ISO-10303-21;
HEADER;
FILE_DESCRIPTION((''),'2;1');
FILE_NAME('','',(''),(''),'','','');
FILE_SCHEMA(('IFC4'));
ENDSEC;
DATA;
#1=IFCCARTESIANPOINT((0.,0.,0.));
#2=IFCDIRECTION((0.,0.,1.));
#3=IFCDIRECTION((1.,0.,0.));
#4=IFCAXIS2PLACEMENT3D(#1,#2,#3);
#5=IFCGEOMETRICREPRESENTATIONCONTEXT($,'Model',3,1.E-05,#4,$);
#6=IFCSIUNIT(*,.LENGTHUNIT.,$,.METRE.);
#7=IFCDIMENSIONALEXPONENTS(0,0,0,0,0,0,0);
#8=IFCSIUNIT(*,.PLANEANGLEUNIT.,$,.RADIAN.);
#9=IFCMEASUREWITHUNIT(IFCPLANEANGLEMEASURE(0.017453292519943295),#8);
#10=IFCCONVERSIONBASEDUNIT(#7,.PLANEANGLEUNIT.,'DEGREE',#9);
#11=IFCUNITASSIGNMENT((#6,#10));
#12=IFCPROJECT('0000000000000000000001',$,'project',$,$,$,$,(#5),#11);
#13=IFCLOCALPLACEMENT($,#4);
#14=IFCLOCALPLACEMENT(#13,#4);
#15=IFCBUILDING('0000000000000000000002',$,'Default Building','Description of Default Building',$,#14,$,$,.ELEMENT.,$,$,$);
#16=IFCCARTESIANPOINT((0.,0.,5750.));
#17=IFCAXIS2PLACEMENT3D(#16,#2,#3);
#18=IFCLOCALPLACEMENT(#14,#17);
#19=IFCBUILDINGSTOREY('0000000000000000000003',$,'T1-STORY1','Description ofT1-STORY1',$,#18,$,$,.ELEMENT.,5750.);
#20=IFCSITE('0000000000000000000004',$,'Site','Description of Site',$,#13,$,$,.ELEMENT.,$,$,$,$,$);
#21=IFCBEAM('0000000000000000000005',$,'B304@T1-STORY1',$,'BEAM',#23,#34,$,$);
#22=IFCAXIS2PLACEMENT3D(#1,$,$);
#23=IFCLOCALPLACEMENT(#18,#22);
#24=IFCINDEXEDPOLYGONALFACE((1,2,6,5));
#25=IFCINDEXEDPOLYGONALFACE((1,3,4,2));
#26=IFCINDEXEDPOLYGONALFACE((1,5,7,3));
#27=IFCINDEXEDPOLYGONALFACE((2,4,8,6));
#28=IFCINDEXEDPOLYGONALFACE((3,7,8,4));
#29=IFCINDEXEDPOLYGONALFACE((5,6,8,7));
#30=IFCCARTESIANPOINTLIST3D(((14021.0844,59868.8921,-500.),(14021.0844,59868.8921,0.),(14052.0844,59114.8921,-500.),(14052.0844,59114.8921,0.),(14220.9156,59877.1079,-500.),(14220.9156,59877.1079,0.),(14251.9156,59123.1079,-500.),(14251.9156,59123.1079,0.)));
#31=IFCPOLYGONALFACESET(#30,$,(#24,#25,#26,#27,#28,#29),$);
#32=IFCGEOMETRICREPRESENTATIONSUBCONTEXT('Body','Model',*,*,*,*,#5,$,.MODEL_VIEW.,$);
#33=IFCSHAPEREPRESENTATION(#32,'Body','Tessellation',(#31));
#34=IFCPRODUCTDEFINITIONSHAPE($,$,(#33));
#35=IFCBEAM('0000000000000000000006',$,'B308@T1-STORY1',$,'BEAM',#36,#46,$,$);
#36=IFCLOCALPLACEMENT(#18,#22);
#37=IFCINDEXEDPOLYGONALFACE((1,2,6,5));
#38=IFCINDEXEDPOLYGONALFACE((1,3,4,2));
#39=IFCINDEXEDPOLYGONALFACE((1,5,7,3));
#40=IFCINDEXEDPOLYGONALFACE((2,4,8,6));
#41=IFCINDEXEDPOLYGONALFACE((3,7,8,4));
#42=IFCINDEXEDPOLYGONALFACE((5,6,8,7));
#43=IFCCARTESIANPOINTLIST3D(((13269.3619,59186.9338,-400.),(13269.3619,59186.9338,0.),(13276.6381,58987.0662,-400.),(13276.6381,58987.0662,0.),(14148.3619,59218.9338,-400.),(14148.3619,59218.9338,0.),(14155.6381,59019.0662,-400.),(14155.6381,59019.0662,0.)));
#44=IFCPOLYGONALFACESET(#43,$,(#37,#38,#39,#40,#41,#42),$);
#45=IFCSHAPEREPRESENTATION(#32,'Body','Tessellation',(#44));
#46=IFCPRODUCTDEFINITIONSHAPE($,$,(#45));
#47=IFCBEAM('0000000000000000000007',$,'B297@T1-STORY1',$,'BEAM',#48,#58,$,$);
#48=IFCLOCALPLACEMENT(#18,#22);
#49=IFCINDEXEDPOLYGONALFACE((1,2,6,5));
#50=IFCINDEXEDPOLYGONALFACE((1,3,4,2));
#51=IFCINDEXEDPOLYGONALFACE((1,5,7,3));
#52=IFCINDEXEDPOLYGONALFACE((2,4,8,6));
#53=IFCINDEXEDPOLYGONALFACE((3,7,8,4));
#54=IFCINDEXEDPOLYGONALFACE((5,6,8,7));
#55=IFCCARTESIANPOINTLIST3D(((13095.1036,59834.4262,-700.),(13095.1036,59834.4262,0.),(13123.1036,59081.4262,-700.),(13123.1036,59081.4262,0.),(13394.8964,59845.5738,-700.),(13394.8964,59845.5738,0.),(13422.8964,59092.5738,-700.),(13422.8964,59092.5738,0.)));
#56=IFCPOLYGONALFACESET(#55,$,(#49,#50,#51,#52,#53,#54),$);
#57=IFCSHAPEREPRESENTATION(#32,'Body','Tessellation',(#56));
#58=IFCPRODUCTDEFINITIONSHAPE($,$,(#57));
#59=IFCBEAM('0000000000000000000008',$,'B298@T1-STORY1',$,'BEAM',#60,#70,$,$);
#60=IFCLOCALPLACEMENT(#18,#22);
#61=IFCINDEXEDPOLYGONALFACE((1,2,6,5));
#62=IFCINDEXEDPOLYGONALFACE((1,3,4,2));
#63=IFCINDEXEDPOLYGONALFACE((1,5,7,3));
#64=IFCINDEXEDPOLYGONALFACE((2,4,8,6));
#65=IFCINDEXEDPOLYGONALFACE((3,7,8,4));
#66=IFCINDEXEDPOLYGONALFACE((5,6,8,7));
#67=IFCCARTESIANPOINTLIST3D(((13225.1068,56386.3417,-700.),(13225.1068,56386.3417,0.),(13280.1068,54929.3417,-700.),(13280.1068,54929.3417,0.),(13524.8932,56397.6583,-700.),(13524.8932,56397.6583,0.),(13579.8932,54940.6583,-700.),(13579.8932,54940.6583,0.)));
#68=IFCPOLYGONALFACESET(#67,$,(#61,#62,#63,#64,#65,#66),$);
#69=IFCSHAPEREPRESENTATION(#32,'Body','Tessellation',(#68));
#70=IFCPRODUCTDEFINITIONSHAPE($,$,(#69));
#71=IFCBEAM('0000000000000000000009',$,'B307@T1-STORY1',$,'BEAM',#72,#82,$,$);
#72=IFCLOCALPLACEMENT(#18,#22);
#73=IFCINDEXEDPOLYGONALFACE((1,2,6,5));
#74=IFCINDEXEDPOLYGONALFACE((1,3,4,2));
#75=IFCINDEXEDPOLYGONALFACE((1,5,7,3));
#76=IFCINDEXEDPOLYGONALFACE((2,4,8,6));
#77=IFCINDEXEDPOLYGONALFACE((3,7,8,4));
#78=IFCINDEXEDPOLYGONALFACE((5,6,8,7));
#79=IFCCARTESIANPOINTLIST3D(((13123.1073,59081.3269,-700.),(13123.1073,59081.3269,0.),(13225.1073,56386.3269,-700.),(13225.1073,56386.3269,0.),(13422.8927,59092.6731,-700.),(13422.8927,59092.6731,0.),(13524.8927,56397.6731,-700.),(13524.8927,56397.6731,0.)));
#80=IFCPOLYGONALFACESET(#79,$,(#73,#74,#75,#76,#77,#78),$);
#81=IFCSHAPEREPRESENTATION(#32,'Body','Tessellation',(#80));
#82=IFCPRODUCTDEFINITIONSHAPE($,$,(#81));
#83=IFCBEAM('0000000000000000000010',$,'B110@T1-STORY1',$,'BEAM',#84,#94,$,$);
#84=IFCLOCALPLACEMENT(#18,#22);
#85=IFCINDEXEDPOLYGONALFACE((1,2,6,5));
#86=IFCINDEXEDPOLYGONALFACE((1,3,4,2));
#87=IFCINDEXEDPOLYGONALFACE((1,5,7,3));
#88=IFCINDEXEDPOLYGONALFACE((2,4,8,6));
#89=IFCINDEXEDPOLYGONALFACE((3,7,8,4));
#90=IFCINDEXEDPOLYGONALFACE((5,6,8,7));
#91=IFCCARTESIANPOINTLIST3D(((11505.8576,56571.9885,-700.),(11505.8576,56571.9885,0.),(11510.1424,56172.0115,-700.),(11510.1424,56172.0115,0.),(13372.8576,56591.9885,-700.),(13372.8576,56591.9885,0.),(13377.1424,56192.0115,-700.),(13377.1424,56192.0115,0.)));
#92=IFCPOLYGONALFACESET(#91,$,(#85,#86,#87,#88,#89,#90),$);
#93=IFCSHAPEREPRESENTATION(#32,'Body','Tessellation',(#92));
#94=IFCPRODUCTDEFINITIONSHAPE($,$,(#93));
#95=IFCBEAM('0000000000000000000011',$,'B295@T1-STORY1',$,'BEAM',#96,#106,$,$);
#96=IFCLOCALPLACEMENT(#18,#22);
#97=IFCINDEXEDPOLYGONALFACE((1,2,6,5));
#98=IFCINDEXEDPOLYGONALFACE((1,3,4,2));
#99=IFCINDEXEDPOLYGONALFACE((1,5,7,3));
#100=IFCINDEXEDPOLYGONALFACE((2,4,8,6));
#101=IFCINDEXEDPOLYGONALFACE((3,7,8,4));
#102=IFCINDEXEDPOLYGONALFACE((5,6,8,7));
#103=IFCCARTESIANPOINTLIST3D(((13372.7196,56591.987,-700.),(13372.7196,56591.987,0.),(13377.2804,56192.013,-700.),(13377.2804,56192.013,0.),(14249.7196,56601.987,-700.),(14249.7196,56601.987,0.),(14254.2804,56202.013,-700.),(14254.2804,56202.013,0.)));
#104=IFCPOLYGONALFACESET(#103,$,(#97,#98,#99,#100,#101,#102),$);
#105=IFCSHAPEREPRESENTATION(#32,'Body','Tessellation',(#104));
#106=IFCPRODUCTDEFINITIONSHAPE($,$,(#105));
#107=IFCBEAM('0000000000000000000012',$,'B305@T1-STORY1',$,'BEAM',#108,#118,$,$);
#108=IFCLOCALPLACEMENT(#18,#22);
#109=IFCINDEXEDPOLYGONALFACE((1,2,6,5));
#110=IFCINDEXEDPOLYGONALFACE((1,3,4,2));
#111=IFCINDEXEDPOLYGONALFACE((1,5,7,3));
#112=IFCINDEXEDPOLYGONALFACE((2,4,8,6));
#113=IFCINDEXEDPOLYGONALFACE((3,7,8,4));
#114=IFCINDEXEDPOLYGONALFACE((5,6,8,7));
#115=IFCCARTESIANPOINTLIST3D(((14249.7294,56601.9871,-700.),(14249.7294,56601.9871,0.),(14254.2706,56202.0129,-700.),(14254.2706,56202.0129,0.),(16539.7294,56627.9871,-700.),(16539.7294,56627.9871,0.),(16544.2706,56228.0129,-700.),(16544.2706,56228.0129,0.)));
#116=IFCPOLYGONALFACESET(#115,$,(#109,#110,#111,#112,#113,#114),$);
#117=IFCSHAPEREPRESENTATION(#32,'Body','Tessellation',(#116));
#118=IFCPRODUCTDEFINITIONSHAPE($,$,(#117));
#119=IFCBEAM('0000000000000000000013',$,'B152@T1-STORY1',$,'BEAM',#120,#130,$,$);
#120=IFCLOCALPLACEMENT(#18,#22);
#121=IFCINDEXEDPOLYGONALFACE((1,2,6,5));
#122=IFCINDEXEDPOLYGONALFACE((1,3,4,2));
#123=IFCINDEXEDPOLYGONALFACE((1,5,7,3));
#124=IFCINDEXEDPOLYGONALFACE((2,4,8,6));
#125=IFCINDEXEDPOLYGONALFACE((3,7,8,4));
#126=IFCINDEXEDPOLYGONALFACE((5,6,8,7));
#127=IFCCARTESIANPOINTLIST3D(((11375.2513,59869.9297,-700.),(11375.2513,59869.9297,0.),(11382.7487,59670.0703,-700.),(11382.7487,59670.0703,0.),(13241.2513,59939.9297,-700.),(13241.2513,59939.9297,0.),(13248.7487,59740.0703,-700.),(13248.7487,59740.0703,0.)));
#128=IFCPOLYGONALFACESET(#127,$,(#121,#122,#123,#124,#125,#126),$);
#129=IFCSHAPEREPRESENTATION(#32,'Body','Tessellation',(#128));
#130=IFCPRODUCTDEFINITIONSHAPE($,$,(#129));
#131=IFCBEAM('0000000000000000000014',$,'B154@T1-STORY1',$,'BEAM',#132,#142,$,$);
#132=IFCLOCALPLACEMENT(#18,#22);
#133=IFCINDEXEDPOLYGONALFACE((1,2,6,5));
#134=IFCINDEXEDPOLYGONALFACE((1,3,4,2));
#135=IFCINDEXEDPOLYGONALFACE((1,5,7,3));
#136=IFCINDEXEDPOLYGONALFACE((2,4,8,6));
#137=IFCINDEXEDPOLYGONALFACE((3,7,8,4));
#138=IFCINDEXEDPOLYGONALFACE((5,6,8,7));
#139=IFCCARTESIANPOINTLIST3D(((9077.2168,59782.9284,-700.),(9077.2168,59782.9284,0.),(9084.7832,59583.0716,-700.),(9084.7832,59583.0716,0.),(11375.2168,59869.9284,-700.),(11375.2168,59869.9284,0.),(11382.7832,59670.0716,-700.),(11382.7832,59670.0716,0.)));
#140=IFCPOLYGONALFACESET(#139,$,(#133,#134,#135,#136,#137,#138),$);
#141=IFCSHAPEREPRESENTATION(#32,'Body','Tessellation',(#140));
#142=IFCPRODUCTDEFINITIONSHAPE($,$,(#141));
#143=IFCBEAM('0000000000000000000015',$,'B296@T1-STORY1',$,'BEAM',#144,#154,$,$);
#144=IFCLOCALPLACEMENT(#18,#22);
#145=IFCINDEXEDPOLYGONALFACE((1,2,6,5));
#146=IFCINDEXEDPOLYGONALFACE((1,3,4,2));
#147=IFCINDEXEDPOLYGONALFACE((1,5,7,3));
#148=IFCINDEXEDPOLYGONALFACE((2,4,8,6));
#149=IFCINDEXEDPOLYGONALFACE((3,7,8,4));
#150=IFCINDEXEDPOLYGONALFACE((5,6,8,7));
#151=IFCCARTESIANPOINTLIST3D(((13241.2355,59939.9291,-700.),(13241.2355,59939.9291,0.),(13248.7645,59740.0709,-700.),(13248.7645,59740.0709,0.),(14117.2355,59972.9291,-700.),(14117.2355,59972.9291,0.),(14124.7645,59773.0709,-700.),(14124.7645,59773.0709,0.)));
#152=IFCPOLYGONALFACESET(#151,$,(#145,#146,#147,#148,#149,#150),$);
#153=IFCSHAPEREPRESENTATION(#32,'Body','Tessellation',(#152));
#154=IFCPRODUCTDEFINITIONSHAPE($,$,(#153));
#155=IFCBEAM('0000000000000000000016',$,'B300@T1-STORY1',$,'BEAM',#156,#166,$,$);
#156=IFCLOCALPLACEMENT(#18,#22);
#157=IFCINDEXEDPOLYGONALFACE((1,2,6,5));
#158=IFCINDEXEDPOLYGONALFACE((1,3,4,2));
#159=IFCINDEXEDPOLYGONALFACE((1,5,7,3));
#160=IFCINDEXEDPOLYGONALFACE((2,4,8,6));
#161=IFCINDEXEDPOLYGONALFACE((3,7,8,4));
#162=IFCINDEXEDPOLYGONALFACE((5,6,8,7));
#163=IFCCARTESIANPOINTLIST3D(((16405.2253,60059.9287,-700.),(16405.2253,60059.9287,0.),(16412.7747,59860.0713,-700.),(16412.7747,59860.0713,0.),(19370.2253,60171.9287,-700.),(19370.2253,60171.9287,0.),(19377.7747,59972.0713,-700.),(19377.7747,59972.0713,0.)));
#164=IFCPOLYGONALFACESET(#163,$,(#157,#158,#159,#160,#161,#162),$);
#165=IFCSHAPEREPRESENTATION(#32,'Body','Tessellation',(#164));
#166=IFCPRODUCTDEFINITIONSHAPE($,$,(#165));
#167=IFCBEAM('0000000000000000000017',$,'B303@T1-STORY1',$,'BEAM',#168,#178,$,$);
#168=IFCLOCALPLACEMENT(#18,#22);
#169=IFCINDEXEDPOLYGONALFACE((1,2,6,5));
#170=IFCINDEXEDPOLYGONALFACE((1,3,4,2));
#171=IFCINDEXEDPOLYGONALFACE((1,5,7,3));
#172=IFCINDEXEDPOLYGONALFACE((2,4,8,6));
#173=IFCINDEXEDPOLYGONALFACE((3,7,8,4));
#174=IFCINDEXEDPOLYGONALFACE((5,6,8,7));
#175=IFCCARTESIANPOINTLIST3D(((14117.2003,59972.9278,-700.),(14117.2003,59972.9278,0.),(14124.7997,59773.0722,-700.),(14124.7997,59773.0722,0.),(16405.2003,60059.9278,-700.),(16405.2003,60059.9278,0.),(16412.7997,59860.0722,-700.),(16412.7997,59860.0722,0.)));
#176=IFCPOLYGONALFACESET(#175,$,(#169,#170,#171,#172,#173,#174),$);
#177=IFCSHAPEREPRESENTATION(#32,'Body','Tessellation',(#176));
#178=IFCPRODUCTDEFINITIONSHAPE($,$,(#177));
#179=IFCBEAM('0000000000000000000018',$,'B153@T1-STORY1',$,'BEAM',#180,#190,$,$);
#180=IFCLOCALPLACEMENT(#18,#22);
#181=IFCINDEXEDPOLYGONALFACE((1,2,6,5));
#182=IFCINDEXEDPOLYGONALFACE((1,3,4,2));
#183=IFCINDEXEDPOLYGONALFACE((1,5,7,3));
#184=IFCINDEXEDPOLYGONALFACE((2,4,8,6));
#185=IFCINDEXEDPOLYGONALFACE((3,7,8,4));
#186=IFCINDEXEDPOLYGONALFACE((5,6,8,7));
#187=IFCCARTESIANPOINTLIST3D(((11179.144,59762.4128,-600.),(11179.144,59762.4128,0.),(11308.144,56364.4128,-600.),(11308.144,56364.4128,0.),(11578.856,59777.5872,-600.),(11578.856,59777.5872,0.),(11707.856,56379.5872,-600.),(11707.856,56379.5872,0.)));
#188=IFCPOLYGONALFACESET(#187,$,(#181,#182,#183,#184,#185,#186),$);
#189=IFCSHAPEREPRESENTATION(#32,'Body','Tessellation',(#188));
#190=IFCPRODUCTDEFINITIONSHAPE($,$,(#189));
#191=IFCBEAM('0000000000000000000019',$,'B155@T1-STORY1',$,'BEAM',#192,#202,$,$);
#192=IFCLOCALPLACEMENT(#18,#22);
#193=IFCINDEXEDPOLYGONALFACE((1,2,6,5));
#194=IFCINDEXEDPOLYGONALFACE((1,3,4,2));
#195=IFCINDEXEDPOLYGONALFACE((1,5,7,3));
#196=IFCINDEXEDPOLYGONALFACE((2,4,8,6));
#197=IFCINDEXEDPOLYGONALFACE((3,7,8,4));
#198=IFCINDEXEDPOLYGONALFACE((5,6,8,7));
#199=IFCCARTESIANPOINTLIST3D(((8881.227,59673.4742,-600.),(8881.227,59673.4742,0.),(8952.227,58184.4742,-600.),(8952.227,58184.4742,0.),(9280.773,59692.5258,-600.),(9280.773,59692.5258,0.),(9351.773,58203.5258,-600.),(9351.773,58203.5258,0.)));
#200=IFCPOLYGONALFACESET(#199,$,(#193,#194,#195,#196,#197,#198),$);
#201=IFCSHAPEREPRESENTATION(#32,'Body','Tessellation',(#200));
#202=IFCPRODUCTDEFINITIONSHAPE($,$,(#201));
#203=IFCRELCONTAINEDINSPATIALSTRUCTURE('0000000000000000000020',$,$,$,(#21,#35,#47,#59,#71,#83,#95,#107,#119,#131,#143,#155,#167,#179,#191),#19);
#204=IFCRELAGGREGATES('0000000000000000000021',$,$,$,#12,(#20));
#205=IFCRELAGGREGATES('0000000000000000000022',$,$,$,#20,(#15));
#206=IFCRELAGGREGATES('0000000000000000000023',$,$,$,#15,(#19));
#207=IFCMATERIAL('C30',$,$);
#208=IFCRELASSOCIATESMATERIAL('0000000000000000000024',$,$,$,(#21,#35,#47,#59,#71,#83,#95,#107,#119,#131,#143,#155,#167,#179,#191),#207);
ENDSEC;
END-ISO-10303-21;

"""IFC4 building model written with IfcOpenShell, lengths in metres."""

from ifc_helpers import new_model, entity, si_unit, converted_unit, frame, origin_with_axes, place, context, subcontext, project, spatial, rectangle, extrude, material, element, save


model = new_model("IFC4")

# Units and contexts
model_context = context("Model", 3, precision=1e-05, world=origin_with_axes())
body_context = subcontext(model_context, "Body", "Model", "MODEL_VIEW")
ifc_project = project(units=[si_unit("LENGTHUNIT", "METRE"), converted_unit("PLANEANGLEUNIT", "DEGREE", entity("IfcPlaneAngleMeasure", 0.017453292519943295), si_unit("PLANEANGLEUNIT", "RADIAN"), dimensions=[0, 0, 0, 0, 0, 0, 0])], contexts=[model_context])

# Site, building, storey
site_placement = place(None, origin_with_axes())
site = spatial("IfcSite", under=ifc_project, at=site_placement, Name="Site", Description="Description of Site", CompositionType="ELEMENT")
building_placement = place(site_placement, origin_with_axes())
building = spatial("IfcBuilding", under=site, at=building_placement, Name="Default Building", Description="Description of Default Building", CompositionType="ELEMENT")
storey_placement = place(building_placement, frame((0.0, 0.0, 5750.0), z_axis=(0.0, 0.0, 1.0), x_axis=(1.0, 0.0, 0.0)))
storey = spatial("IfcBuildingStorey", under=building, at=storey_placement, Name="T1-STORY1", Description="Description ofT1-STORY1", CompositionType="ELEMENT", Elevation=5750.0)

# Beams
ifc_material_1 = material(Name="C30")
beam_1_placement = place(storey_placement, frame((14121.0, 59873.0, -250.0), z_axis=(0.041079, -0.999156, 0.0), x_axis=(0.999156, 0.041079, 0.0)))
element("IfcBeam", 1, at=beam_1_placement, inside=storey, material=ifc_material_1, Name="B304@T1-STORY1", ObjectType="BEAM", context=body_context, shape_type="SweptSolid", body=[
    extrude(rectangle(XDim=200.0, YDim=500.0), origin_with_axes(), (0.0, 0.0, 1.0), 754.637),
])
beam_2_placement = place(storey_placement, frame((13273.0, 59087.0, -200.0), z_axis=(0.999338, 0.036381, 0.0), x_axis=(-0.036381, 0.999338, 0.0)))
element("IfcBeam", 2, at=beam_2_placement, inside=storey, material=ifc_material_1, Name="B308@T1-STORY1", ObjectType="BEAM", context=body_context, shape_type="SweptSolid", body=[
    extrude(rectangle(XDim=200.0, YDim=400.0), origin_with_axes(), (0.0, 0.0, 1.0), 879.5823),
])
beam_3_placement = place(storey_placement, frame((13245.0, 59840.0, -350.0), z_axis=(0.037159, -0.999309, 0.0), x_axis=(0.999309, 0.037159, 0.0)))
element("IfcBeam", 3, at=beam_3_placement, inside=storey, material=ifc_material_1, Name="B297@T1-STORY1", ObjectType="BEAM", context=body_context, shape_type="SweptSolid", body=[
    extrude(rectangle(XDim=300.0, YDim=700.0), origin_with_axes(), (0.0, 0.0, 1.0), 753.5204),
])
beam_4_placement = place(storey_placement, frame((13375.0, 56392.0, -350.0), z_axis=(0.037722, -0.999288, 0.0), x_axis=(0.999288, 0.037722, 0.0)))
element("IfcBeam", 4, at=beam_4_placement, inside=storey, material=ifc_material_1, Name="B298@T1-STORY1", ObjectType="BEAM", context=body_context, shape_type="SweptSolid", body=[
    extrude(rectangle(XDim=300.0, YDim=700.0), origin_with_axes(), (0.0, 0.0, 1.0), 1458.0377),
])
beam_5_placement = place(storey_placement, frame((13273.0, 59087.0, -350.0), z_axis=(0.037821, -0.999285, 0.0), x_axis=(0.999285, 0.037821, 0.0)))
element("IfcBeam", 5, at=beam_5_placement, inside=storey, material=ifc_material_1, Name="B307@T1-STORY1", ObjectType="BEAM", context=body_context, shape_type="SweptSolid", body=[
    extrude(rectangle(XDim=300.0, YDim=700.0), origin_with_axes(), (0.0, 0.0, 1.0), 2696.9296),
])
beam_6_placement = place(storey_placement, frame((11508.0, 56372.0, -350.0), z_axis=(0.999943, 0.010712, 0.0), x_axis=(-0.010712, 0.999943, 0.0)))
element("IfcBeam", 6, at=beam_6_placement, inside=storey, material=ifc_material_1, Name="B110@T1-STORY1", ObjectType="BEAM", context=body_context, shape_type="SweptSolid", body=[
    extrude(rectangle(XDim=400.0, YDim=700.0), origin_with_axes(), (0.0, 0.0, 1.0), 1867.1071),
])
beam_7_placement = place(storey_placement, frame((13375.0, 56392.0, -350.0), z_axis=(0.999935, 0.011402, 0.0), x_axis=(-0.011402, 0.999935, 0.0)))
element("IfcBeam", 7, at=beam_7_placement, inside=storey, material=ifc_material_1, Name="B295@T1-STORY1", ObjectType="BEAM", context=body_context, shape_type="SweptSolid", body=[
    extrude(rectangle(XDim=400.0, YDim=700.0), origin_with_axes(), (0.0, 0.0, 1.0), 877.057),
])
beam_8_placement = place(storey_placement, frame((14252.0, 56402.0, -350.0), z_axis=(0.999936, 0.011353, 0.0), x_axis=(-0.011353, 0.999936, 0.0)))
element("IfcBeam", 8, at=beam_8_placement, inside=storey, material=ifc_material_1, Name="B305@T1-STORY1", ObjectType="BEAM", context=body_context, shape_type="SweptSolid", body=[
    extrude(rectangle(XDim=400.0, YDim=700.0), origin_with_axes(), (0.0, 0.0, 1.0), 2290.1476),
])
beam_9_placement = place(storey_placement, frame((11379.0, 59770.0, -350.0), z_axis=(0.999297, 0.037487, 0.0), x_axis=(-0.037487, 0.999297, 0.0)))
element("IfcBeam", 9, at=beam_9_placement, inside=storey, material=ifc_material_1, Name="B152@T1-STORY1", ObjectType="BEAM", context=body_context, shape_type="SweptSolid", body=[
    extrude(rectangle(XDim=200.0, YDim=700.0), origin_with_axes(), (0.0, 0.0, 1.0), 1867.3125),
])
beam_10_placement = place(storey_placement, frame((9081.0, 59683.0, -350.0), z_axis=(0.999284, 0.037832, 0.0), x_axis=(-0.037832, 0.999284, 0.0)))
element("IfcBeam", 10, at=beam_10_placement, inside=storey, material=ifc_material_1, Name="B154@T1-STORY1", ObjectType="BEAM", context=body_context, shape_type="SweptSolid", body=[
    extrude(rectangle(XDim=200.0, YDim=700.0), origin_with_axes(), (0.0, 0.0, 1.0), 2299.6463),
])
beam_11_placement = place(storey_placement, frame((13245.0, 59840.0, -350.0), z_axis=(0.999291, 0.037645, 0.0), x_axis=(-0.037645, 0.999291, 0.0)))
element("IfcBeam", 11, at=beam_11_placement, inside=storey, material=ifc_material_1, Name="B296@T1-STORY1", ObjectType="BEAM", context=body_context, shape_type="SweptSolid", body=[
    extrude(rectangle(XDim=200.0, YDim=700.0), origin_with_axes(), (0.0, 0.0, 1.0), 876.6214),
])
beam_12_placement = place(storey_placement, frame((16409.0, 59960.0, -350.0), z_axis=(0.999287, 0.037747, 0.0), x_axis=(-0.037747, 0.999287, 0.0)))
element("IfcBeam", 12, at=beam_12_placement, inside=storey, material=ifc_material_1, Name="B300@T1-STORY1", ObjectType="BEAM", context=body_context, shape_type="SweptSolid", body=[
    extrude(rectangle(XDim=200.0, YDim=700.0), origin_with_axes(), (0.0, 0.0, 1.0), 2967.1146),
])
beam_13_placement = place(storey_placement, frame((14121.0, 59873.0, -350.0), z_axis=(0.999278, 0.037997, 0.0), x_axis=(-0.037997, 0.999278, 0.0)))
element("IfcBeam", 13, at=beam_13_placement, inside=storey, material=ifc_material_1, Name="B303@T1-STORY1", ObjectType="BEAM", context=body_context, shape_type="SweptSolid", body=[
    extrude(rectangle(XDim=200.0, YDim=700.0), origin_with_axes(), (0.0, 0.0, 1.0), 2289.6535),
])
beam_14_placement = place(storey_placement, frame((11379.0, 59770.0, -300.0), z_axis=(0.037936, -0.99928, 0.0), x_axis=(0.99928, 0.037936, 0.0)))
element("IfcBeam", 14, at=beam_14_placement, inside=storey, material=ifc_material_1, Name="B153@T1-STORY1", ObjectType="BEAM", context=body_context, shape_type="SweptSolid", body=[
    extrude(rectangle(XDim=400.0, YDim=600.0), origin_with_axes(), (0.0, 0.0, 1.0), 3400.4478),
])
beam_15_placement = place(storey_placement, frame((9081.0, 59683.0, -300.0), z_axis=(0.047629, -0.998865, 0.0), x_axis=(0.998865, 0.047629, 0.0)))
element("IfcBeam", 15, at=beam_15_placement, inside=storey, material=ifc_material_1, Name="B155@T1-STORY1", ObjectType="BEAM", context=body_context, shape_type="SweptSolid", body=[
    extrude(rectangle(XDim=400.0, YDim=600.0), origin_with_axes(), (0.0, 0.0, 1.0), 1490.6918),
])

save(model, "model.ifc")
